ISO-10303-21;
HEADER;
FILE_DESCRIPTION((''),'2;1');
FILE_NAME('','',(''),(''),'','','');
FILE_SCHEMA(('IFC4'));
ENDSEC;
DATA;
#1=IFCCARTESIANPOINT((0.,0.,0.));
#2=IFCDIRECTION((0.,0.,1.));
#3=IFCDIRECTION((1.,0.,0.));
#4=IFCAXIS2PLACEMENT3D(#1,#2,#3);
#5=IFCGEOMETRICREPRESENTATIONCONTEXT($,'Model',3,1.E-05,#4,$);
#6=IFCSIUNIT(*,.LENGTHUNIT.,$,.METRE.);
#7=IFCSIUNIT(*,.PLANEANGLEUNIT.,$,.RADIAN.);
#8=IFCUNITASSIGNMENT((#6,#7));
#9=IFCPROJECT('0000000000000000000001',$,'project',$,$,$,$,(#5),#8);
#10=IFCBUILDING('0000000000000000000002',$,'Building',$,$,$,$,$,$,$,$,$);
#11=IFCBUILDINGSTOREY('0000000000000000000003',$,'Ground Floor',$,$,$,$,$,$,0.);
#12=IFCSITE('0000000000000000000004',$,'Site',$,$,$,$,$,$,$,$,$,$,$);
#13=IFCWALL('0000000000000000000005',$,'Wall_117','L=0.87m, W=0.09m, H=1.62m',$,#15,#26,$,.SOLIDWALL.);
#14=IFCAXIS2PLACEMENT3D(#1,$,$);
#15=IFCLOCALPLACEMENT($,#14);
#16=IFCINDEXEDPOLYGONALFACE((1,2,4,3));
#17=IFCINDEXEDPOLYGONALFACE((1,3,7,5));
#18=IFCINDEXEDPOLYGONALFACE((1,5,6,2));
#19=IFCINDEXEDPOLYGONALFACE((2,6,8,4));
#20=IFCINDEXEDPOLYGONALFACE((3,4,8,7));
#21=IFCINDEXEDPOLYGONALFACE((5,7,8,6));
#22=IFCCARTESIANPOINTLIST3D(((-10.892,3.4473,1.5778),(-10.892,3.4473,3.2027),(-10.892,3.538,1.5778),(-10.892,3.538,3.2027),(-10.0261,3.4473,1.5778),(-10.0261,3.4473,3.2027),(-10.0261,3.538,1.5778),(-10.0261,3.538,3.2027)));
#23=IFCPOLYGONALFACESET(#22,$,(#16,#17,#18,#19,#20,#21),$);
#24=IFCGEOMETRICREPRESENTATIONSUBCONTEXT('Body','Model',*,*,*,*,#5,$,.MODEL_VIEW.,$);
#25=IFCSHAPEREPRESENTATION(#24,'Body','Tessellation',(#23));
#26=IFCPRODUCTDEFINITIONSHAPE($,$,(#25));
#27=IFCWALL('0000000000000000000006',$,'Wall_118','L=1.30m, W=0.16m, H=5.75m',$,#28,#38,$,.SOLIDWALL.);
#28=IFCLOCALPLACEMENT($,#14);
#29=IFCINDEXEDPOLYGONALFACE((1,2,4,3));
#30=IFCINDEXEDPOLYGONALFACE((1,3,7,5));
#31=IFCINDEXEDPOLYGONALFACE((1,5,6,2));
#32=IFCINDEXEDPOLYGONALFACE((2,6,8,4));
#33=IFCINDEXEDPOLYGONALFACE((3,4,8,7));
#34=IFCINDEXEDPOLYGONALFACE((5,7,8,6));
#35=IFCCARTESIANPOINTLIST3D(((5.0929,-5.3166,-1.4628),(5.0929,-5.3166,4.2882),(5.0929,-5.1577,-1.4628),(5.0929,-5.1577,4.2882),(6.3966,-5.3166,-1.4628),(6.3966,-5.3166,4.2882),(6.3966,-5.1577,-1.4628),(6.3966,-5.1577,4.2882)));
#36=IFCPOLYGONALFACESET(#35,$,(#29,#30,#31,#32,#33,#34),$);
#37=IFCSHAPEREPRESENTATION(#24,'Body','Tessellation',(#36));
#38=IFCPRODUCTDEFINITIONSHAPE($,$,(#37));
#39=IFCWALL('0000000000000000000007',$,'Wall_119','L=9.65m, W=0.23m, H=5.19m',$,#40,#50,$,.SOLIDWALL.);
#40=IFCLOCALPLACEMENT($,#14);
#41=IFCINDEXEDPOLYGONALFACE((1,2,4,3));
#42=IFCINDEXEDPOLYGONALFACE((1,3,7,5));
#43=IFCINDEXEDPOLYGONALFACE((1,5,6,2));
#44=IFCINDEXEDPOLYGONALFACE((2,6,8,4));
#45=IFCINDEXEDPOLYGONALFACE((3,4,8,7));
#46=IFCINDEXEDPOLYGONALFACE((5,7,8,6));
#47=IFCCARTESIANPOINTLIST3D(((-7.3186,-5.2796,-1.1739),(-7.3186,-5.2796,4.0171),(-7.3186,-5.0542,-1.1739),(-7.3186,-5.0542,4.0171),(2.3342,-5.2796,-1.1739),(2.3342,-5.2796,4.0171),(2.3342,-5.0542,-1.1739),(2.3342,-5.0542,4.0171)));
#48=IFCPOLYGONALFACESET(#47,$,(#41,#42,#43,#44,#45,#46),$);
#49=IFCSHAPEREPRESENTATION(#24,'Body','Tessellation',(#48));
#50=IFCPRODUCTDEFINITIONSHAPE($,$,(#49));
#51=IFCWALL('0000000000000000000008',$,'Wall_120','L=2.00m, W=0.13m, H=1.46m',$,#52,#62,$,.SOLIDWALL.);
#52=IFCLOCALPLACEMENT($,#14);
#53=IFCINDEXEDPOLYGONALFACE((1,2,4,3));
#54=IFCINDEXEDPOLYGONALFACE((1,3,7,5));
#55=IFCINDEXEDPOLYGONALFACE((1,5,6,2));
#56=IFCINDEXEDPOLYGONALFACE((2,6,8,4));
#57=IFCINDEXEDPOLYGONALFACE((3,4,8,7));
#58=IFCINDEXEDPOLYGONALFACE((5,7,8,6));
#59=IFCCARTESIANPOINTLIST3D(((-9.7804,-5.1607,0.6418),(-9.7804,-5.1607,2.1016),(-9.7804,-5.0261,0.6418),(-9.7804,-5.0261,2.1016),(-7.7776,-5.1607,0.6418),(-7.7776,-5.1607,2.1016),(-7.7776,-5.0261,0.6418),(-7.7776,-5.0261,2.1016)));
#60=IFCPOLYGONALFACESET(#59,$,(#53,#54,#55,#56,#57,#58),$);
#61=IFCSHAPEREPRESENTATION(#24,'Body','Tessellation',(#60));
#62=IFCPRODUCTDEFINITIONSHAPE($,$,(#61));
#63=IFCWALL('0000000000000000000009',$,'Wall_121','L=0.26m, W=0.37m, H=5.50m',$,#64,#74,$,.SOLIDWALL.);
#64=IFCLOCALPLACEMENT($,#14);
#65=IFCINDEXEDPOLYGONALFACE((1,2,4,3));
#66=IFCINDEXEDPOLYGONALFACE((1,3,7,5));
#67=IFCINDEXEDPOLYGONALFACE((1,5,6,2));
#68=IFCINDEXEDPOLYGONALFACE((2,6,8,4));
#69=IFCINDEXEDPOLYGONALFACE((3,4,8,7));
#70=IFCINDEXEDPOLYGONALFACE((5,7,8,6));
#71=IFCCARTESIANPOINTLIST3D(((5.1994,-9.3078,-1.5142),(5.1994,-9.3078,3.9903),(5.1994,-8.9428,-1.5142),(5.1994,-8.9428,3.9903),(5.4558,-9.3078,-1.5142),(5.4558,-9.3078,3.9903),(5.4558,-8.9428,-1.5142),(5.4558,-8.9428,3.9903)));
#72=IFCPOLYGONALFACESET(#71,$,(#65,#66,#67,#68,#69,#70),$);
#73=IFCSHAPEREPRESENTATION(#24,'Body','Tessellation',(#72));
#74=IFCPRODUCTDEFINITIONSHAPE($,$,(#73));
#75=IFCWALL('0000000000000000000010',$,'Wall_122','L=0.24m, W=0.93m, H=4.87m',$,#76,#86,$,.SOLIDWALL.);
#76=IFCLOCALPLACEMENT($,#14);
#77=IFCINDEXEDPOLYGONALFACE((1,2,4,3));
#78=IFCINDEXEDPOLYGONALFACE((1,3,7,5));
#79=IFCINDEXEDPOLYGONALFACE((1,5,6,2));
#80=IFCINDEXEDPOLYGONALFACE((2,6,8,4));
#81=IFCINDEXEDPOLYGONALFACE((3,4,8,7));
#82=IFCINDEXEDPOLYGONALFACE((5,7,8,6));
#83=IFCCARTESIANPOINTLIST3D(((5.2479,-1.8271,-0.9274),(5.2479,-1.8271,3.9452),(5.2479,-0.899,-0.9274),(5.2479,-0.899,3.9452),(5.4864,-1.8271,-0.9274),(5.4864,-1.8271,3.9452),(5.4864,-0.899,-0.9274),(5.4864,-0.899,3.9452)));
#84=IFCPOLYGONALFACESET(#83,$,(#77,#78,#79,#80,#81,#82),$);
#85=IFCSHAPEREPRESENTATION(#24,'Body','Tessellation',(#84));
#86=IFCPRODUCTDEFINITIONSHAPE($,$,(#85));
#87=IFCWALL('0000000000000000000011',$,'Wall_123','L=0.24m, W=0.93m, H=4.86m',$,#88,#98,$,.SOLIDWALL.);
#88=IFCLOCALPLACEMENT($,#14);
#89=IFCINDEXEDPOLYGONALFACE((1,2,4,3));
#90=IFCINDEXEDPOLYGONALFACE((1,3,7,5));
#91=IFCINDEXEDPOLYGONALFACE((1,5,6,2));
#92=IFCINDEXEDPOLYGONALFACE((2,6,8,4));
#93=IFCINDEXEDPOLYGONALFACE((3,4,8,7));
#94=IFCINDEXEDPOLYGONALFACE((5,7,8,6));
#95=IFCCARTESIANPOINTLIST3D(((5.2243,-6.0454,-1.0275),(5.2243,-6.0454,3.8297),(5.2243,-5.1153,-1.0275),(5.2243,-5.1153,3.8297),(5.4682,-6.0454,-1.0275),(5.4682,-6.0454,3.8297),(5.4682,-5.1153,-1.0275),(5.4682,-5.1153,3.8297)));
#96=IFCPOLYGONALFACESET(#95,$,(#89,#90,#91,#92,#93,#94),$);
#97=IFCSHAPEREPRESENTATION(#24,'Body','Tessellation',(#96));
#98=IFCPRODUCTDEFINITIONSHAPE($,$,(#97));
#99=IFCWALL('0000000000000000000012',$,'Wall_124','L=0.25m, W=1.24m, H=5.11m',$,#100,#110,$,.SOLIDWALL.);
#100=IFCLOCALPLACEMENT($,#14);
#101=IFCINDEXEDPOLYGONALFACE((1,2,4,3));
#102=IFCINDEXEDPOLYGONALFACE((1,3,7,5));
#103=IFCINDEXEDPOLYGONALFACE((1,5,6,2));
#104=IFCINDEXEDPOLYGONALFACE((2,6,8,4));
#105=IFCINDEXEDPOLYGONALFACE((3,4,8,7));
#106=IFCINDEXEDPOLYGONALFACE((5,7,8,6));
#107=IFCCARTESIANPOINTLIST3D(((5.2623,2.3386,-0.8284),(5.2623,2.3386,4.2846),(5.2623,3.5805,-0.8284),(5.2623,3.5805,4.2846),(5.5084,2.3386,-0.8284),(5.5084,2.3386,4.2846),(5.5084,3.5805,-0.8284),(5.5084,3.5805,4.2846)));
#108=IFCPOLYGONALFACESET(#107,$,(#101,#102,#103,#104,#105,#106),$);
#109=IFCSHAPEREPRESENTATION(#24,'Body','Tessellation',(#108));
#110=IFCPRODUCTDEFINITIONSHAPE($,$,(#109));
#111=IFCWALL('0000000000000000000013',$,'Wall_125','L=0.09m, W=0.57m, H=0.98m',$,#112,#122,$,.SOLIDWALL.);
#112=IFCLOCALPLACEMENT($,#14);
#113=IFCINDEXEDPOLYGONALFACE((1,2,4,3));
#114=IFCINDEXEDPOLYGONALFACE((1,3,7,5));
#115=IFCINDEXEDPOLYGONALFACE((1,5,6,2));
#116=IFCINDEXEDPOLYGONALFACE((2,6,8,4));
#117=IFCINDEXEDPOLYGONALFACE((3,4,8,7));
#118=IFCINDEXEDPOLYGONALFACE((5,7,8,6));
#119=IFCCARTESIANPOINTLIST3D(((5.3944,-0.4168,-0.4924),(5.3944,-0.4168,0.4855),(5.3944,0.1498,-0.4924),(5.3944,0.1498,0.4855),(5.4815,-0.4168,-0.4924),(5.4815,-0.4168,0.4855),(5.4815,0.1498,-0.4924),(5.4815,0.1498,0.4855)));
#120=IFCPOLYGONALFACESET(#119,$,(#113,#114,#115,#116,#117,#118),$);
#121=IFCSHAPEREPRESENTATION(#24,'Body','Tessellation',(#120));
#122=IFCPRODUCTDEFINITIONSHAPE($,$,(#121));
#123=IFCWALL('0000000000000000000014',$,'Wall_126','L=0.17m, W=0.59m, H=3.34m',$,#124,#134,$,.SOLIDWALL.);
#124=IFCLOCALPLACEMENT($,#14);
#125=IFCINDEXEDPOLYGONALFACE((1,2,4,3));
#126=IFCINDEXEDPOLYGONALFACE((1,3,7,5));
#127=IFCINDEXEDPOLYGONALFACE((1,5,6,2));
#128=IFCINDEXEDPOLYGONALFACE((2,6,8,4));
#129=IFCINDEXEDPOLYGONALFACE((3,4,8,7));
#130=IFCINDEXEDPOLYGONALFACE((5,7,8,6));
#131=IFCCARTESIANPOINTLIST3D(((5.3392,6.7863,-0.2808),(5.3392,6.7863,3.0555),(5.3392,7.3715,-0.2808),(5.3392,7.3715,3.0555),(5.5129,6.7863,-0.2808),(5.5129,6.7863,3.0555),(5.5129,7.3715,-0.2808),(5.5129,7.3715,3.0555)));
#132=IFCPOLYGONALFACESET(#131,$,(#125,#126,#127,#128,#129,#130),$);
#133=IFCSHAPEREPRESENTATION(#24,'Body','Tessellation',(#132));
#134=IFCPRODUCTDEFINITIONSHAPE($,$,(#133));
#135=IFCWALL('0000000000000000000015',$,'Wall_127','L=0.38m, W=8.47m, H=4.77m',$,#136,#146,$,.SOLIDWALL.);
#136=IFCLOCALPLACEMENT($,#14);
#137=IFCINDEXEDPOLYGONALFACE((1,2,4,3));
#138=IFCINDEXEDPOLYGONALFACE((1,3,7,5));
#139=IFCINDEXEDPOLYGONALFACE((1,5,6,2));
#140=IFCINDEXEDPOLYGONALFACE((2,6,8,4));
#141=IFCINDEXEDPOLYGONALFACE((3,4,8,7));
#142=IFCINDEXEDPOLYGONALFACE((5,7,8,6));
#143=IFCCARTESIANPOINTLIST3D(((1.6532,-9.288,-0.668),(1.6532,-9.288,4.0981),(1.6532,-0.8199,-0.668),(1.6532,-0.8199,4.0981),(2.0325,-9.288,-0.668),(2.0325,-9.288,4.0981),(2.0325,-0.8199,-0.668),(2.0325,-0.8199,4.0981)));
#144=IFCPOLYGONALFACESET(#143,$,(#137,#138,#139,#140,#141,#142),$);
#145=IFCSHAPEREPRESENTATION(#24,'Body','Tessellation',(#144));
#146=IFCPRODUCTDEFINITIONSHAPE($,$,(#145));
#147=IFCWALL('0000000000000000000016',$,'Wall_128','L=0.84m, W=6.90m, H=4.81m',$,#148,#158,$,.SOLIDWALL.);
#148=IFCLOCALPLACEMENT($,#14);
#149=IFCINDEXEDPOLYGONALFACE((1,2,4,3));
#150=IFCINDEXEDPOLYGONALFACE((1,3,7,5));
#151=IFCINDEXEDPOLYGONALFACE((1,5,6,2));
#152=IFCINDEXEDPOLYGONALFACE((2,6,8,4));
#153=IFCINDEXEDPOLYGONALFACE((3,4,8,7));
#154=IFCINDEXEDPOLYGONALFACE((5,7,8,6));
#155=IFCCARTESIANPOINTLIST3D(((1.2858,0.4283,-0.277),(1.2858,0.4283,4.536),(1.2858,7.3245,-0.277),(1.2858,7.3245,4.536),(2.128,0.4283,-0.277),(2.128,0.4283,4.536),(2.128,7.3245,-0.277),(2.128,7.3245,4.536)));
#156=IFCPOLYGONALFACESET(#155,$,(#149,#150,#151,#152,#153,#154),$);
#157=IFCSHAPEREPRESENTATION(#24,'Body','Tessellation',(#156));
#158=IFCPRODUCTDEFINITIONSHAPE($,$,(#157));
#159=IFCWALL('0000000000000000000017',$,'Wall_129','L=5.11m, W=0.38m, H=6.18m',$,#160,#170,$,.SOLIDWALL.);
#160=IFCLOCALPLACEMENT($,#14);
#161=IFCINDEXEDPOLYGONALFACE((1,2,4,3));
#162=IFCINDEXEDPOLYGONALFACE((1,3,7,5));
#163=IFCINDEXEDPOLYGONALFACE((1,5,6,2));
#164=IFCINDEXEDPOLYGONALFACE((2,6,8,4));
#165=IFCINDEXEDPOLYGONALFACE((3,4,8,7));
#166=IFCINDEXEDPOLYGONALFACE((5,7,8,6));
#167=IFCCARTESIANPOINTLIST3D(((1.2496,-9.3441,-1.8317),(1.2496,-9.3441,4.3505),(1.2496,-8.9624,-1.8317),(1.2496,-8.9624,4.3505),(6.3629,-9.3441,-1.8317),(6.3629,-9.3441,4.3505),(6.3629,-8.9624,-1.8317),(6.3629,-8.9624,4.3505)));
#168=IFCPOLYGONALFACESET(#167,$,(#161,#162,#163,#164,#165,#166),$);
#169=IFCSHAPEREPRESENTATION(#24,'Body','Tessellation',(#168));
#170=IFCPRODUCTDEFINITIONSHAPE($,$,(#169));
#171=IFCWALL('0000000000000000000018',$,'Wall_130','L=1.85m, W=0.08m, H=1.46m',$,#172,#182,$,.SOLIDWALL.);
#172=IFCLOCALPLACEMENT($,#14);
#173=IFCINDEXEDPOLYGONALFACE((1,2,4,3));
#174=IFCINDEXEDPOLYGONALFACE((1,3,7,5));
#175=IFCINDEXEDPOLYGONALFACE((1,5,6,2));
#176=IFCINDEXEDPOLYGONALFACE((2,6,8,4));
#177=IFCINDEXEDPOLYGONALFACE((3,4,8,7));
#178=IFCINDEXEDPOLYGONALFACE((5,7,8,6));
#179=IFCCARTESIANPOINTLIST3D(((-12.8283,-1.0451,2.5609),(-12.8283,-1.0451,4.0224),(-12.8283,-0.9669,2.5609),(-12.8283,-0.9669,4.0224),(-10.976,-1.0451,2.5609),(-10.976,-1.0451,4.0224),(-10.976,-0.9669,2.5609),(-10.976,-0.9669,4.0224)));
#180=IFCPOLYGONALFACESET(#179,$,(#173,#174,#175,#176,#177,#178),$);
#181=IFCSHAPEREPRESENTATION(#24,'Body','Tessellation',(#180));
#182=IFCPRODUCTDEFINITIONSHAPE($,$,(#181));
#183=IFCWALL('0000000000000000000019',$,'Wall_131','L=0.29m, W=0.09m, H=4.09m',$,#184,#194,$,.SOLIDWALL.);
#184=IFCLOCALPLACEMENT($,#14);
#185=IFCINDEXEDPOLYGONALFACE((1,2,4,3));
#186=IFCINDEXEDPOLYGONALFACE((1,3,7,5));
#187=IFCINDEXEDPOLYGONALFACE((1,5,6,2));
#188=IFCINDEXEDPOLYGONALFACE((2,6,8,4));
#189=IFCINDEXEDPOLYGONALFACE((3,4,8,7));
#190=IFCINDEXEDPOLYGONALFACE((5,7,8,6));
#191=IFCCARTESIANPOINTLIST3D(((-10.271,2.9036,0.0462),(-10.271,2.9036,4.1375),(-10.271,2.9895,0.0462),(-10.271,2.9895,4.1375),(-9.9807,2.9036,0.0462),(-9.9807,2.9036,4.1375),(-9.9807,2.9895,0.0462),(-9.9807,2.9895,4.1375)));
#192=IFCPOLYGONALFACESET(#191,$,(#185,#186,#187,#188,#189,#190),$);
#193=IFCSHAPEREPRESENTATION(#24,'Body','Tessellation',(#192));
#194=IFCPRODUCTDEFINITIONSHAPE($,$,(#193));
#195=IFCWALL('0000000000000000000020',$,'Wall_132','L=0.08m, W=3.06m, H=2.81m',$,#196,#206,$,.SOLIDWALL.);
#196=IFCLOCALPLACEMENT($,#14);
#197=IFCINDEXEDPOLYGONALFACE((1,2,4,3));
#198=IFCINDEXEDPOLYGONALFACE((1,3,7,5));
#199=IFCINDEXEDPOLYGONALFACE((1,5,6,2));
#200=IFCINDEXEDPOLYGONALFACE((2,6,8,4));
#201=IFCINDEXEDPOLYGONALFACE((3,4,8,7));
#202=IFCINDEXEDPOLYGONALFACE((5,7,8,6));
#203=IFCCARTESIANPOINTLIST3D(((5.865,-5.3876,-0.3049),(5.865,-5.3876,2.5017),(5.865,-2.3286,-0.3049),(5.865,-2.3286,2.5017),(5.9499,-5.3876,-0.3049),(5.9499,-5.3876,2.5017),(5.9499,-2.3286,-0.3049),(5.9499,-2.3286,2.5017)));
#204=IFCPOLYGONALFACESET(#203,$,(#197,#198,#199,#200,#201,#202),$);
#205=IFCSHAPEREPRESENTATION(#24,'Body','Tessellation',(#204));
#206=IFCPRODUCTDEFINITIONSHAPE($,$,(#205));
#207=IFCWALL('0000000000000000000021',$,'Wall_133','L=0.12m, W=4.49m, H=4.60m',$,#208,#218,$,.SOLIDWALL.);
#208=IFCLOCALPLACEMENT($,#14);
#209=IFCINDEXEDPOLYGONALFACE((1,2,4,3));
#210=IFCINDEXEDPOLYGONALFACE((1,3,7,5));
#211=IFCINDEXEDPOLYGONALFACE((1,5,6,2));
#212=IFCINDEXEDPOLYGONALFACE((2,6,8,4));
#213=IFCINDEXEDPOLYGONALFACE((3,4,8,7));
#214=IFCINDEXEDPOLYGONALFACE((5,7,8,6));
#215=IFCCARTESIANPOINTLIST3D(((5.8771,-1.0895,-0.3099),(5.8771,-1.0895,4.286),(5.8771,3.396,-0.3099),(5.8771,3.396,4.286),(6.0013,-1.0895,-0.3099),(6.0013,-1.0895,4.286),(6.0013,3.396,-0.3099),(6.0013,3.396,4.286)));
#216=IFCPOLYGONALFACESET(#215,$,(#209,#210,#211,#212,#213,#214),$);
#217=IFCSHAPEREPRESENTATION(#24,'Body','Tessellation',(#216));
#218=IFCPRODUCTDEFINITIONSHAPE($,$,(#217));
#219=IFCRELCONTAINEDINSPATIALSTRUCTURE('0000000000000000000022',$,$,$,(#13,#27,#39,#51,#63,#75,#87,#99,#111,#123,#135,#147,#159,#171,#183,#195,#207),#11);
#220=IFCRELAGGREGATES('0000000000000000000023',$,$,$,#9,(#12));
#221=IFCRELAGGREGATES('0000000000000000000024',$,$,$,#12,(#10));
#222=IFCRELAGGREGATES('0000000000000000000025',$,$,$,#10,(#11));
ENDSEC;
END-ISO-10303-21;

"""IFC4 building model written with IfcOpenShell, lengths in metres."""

from ifc_helpers import new_model, si_unit, frame, origin_with_axes, origin_2d, context, subcontext, project, spatial, rectangle, extrude, element, save


model = new_model("IFC4")

# Units and contexts
model_context = context("Model", 3, precision=1e-05, world=origin_with_axes())
body_context = subcontext(model_context, "Body", "Model", "MODEL_VIEW")
ifc_project = project(units=[si_unit("LENGTHUNIT", "METRE"), si_unit("PLANEANGLEUNIT", "RADIAN")], contexts=[model_context])

# Site, building, storey
site = spatial("IfcSite", under=ifc_project, Name="Site")
building = spatial("IfcBuilding", under=site, Name="Building")
storey = spatial("IfcBuildingStorey", under=building, Name="Ground Floor", Elevation=0.0)

# Walls
element("IfcWall", 1, inside=storey, Name="Wall_117", Description="L=0.87m, W=0.09m, H=1.62m", PredefinedType="SOLIDWALL", context=body_context, shape_type="SweptSolid", body=[
    extrude(rectangle(XDim=0.8659, YDim=0.0907, at=origin_2d()), frame((-10.4591, 3.4926, 1.5778), z_axis=(0.0, 0.0, 1.0), x_axis=(1.0, 0.0, 0.0)), (0.0, 0.0, 1.0), 1.6249),
])
element("IfcWall", 2, inside=storey, Name="Wall_118", Description="L=1.30m, W=0.16m, H=5.75m", PredefinedType="SOLIDWALL", context=body_context, shape_type="SweptSolid", body=[
    extrude(rectangle(XDim=1.3037, YDim=0.1589, at=origin_2d()), frame((5.7448, -5.2371, -1.4628), z_axis=(0.0, 0.0, 1.0), x_axis=(1.0, 0.0, 0.0)), (0.0, 0.0, 1.0), 5.751),
])
element("IfcWall", 3, inside=storey, Name="Wall_119", Description="L=9.65m, W=0.23m, H=5.19m", PredefinedType="SOLIDWALL", context=body_context, shape_type="SweptSolid", body=[
    extrude(rectangle(XDim=9.6528, YDim=0.2254, at=origin_2d()), frame((-2.4922, -5.1669, -1.1739), z_axis=(0.0, 0.0, 1.0), x_axis=(1.0, 0.0, 0.0)), (0.0, 0.0, 1.0), 5.191),
])
element("IfcWall", 4, inside=storey, Name="Wall_120", Description="L=2.00m, W=0.13m, H=1.46m", PredefinedType="SOLIDWALL", context=body_context, shape_type="SweptSolid", body=[
    extrude(rectangle(XDim=2.0028, YDim=0.1346, at=origin_2d()), frame((-8.779, -5.0934, 0.6418), z_axis=(0.0, 0.0, 1.0), x_axis=(1.0, 0.0, 0.0)), (0.0, 0.0, 1.0), 1.4598),
])
element("IfcWall", 5, inside=storey, Name="Wall_121", Description="L=0.26m, W=0.37m, H=5.50m", PredefinedType="SOLIDWALL", context=body_context, shape_type="SweptSolid", body=[
    extrude(rectangle(XDim=0.2563, YDim=0.365, at=origin_2d()), frame((5.3276, -9.1253, -1.5142), z_axis=(0.0, 0.0, 1.0), x_axis=(1.0, 0.0, 0.0)), (0.0, 0.0, 1.0), 5.5045),
])
element("IfcWall", 6, inside=storey, Name="Wall_122", Description="L=0.24m, W=0.93m, H=4.87m", PredefinedType="SOLIDWALL", context=body_context, shape_type="SweptSolid", body=[
    extrude(rectangle(XDim=0.2385, YDim=0.9281, at=origin_2d()), frame((5.3671, -1.3631, -0.9274), z_axis=(0.0, 0.0, 1.0), x_axis=(1.0, 0.0, 0.0)), (0.0, 0.0, 1.0), 4.8725),
])
element("IfcWall", 7, inside=storey, Name="Wall_123", Description="L=0.24m, W=0.93m, H=4.86m", PredefinedType="SOLIDWALL", context=body_context, shape_type="SweptSolid", body=[
    extrude(rectangle(XDim=0.2439, YDim=0.9301, at=origin_2d()), frame((5.3463, -5.5804, -1.0275), z_axis=(0.0, 0.0, 1.0), x_axis=(1.0, 0.0, 0.0)), (0.0, 0.0, 1.0), 4.8572),
])
element("IfcWall", 8, inside=storey, Name="Wall_124", Description="L=0.25m, W=1.24m, H=5.11m", PredefinedType="SOLIDWALL", context=body_context, shape_type="SweptSolid", body=[
    extrude(rectangle(XDim=0.2461, YDim=1.2418, at=origin_2d()), frame((5.3853, 2.9595, -0.8284), z_axis=(0.0, 0.0, 1.0), x_axis=(1.0, 0.0, 0.0)), (0.0, 0.0, 1.0), 5.113),
])
element("IfcWall", 9, inside=storey, Name="Wall_125", Description="L=0.09m, W=0.57m, H=0.98m", PredefinedType="SOLIDWALL", context=body_context, shape_type="SweptSolid", body=[
    extrude(rectangle(XDim=0.0871, YDim=0.5666, at=origin_2d()), frame((5.438, -0.1335, -0.4924), z_axis=(0.0, 0.0, 1.0), x_axis=(1.0, 0.0, 0.0)), (0.0, 0.0, 1.0), 0.9779),
])
element("IfcWall", 10, inside=storey, Name="Wall_126", Description="L=0.17m, W=0.59m, H=3.34m", PredefinedType="SOLIDWALL", context=body_context, shape_type="SweptSolid", body=[
    extrude(rectangle(XDim=0.1738, YDim=0.5852, at=origin_2d()), frame((5.4261, 7.0789, -0.2808), z_axis=(0.0, 0.0, 1.0), x_axis=(1.0, 0.0, 0.0)), (0.0, 0.0, 1.0), 3.3363),
])
element("IfcWall", 11, inside=storey, Name="Wall_127", Description="L=0.38m, W=8.47m, H=4.77m", PredefinedType="SOLIDWALL", context=body_context, shape_type="SweptSolid", body=[
    extrude(rectangle(XDim=0.3793, YDim=8.4681, at=origin_2d()), frame((1.8429, -5.054, -0.668), z_axis=(0.0, 0.0, 1.0), x_axis=(1.0, 0.0, 0.0)), (0.0, 0.0, 1.0), 4.7661),
])
element("IfcWall", 12, inside=storey, Name="Wall_128", Description="L=0.84m, W=6.90m, H=4.81m", PredefinedType="SOLIDWALL", context=body_context, shape_type="SweptSolid", body=[
    extrude(rectangle(XDim=0.8422, YDim=6.8962, at=origin_2d()), frame((1.7069, 3.8764, -0.277), z_axis=(0.0, 0.0, 1.0), x_axis=(1.0, 0.0, 0.0)), (0.0, 0.0, 1.0), 4.8129),
])
element("IfcWall", 13, inside=storey, Name="Wall_129", Description="L=5.11m, W=0.38m, H=6.18m", PredefinedType="SOLIDWALL", context=body_context, shape_type="SweptSolid", body=[
    extrude(rectangle(XDim=5.1133, YDim=0.3817, at=origin_2d()), frame((3.8063, -9.1532, -1.8317), z_axis=(0.0, 0.0, 1.0), x_axis=(1.0, 0.0, 0.0)), (0.0, 0.0, 1.0), 6.1822),
])
element("IfcWall", 14, inside=storey, Name="Wall_130", Description="L=1.85m, W=0.08m, H=1.46m", PredefinedType="SOLIDWALL", context=body_context, shape_type="SweptSolid", body=[
    extrude(rectangle(XDim=1.8523, YDim=0.0783, at=origin_2d()), frame((-11.9021, -1.006, 2.5609), z_axis=(0.0, 0.0, 1.0), x_axis=(1.0, 0.0, 0.0)), (0.0, 0.0, 1.0), 1.4615),
])
element("IfcWall", 15, inside=storey, Name="Wall_131", Description="L=0.29m, W=0.09m, H=4.09m", PredefinedType="SOLIDWALL", context=body_context, shape_type="SweptSolid", body=[
    extrude(rectangle(XDim=0.2903, YDim=0.0859, at=origin_2d()), frame((-10.1258, 2.9466, 0.0462), z_axis=(0.0, 0.0, 1.0), x_axis=(1.0, 0.0, 0.0)), (0.0, 0.0, 1.0), 4.0912),
])
element("IfcWall", 16, inside=storey, Name="Wall_132", Description="L=0.08m, W=3.06m, H=2.81m", PredefinedType="SOLIDWALL", context=body_context, shape_type="SweptSolid", body=[
    extrude(rectangle(XDim=0.0849, YDim=3.059, at=origin_2d()), frame((5.9074, -3.8581, -0.3049), z_axis=(0.0, 0.0, 1.0), x_axis=(1.0, 0.0, 0.0)), (0.0, 0.0, 1.0), 2.8066),
])
element("IfcWall", 17, inside=storey, Name="Wall_133", Description="L=0.12m, W=4.49m, H=4.60m", PredefinedType="SOLIDWALL", context=body_context, shape_type="SweptSolid", body=[
    extrude(rectangle(XDim=0.1242, YDim=4.4854, at=origin_2d()), frame((5.9392, 1.1533, -0.3099), z_axis=(0.0, 0.0, 1.0), x_axis=(1.0, 0.0, 0.0)), (0.0, 0.0, 1.0), 4.5959),
])

save(model, "model.ifc")
